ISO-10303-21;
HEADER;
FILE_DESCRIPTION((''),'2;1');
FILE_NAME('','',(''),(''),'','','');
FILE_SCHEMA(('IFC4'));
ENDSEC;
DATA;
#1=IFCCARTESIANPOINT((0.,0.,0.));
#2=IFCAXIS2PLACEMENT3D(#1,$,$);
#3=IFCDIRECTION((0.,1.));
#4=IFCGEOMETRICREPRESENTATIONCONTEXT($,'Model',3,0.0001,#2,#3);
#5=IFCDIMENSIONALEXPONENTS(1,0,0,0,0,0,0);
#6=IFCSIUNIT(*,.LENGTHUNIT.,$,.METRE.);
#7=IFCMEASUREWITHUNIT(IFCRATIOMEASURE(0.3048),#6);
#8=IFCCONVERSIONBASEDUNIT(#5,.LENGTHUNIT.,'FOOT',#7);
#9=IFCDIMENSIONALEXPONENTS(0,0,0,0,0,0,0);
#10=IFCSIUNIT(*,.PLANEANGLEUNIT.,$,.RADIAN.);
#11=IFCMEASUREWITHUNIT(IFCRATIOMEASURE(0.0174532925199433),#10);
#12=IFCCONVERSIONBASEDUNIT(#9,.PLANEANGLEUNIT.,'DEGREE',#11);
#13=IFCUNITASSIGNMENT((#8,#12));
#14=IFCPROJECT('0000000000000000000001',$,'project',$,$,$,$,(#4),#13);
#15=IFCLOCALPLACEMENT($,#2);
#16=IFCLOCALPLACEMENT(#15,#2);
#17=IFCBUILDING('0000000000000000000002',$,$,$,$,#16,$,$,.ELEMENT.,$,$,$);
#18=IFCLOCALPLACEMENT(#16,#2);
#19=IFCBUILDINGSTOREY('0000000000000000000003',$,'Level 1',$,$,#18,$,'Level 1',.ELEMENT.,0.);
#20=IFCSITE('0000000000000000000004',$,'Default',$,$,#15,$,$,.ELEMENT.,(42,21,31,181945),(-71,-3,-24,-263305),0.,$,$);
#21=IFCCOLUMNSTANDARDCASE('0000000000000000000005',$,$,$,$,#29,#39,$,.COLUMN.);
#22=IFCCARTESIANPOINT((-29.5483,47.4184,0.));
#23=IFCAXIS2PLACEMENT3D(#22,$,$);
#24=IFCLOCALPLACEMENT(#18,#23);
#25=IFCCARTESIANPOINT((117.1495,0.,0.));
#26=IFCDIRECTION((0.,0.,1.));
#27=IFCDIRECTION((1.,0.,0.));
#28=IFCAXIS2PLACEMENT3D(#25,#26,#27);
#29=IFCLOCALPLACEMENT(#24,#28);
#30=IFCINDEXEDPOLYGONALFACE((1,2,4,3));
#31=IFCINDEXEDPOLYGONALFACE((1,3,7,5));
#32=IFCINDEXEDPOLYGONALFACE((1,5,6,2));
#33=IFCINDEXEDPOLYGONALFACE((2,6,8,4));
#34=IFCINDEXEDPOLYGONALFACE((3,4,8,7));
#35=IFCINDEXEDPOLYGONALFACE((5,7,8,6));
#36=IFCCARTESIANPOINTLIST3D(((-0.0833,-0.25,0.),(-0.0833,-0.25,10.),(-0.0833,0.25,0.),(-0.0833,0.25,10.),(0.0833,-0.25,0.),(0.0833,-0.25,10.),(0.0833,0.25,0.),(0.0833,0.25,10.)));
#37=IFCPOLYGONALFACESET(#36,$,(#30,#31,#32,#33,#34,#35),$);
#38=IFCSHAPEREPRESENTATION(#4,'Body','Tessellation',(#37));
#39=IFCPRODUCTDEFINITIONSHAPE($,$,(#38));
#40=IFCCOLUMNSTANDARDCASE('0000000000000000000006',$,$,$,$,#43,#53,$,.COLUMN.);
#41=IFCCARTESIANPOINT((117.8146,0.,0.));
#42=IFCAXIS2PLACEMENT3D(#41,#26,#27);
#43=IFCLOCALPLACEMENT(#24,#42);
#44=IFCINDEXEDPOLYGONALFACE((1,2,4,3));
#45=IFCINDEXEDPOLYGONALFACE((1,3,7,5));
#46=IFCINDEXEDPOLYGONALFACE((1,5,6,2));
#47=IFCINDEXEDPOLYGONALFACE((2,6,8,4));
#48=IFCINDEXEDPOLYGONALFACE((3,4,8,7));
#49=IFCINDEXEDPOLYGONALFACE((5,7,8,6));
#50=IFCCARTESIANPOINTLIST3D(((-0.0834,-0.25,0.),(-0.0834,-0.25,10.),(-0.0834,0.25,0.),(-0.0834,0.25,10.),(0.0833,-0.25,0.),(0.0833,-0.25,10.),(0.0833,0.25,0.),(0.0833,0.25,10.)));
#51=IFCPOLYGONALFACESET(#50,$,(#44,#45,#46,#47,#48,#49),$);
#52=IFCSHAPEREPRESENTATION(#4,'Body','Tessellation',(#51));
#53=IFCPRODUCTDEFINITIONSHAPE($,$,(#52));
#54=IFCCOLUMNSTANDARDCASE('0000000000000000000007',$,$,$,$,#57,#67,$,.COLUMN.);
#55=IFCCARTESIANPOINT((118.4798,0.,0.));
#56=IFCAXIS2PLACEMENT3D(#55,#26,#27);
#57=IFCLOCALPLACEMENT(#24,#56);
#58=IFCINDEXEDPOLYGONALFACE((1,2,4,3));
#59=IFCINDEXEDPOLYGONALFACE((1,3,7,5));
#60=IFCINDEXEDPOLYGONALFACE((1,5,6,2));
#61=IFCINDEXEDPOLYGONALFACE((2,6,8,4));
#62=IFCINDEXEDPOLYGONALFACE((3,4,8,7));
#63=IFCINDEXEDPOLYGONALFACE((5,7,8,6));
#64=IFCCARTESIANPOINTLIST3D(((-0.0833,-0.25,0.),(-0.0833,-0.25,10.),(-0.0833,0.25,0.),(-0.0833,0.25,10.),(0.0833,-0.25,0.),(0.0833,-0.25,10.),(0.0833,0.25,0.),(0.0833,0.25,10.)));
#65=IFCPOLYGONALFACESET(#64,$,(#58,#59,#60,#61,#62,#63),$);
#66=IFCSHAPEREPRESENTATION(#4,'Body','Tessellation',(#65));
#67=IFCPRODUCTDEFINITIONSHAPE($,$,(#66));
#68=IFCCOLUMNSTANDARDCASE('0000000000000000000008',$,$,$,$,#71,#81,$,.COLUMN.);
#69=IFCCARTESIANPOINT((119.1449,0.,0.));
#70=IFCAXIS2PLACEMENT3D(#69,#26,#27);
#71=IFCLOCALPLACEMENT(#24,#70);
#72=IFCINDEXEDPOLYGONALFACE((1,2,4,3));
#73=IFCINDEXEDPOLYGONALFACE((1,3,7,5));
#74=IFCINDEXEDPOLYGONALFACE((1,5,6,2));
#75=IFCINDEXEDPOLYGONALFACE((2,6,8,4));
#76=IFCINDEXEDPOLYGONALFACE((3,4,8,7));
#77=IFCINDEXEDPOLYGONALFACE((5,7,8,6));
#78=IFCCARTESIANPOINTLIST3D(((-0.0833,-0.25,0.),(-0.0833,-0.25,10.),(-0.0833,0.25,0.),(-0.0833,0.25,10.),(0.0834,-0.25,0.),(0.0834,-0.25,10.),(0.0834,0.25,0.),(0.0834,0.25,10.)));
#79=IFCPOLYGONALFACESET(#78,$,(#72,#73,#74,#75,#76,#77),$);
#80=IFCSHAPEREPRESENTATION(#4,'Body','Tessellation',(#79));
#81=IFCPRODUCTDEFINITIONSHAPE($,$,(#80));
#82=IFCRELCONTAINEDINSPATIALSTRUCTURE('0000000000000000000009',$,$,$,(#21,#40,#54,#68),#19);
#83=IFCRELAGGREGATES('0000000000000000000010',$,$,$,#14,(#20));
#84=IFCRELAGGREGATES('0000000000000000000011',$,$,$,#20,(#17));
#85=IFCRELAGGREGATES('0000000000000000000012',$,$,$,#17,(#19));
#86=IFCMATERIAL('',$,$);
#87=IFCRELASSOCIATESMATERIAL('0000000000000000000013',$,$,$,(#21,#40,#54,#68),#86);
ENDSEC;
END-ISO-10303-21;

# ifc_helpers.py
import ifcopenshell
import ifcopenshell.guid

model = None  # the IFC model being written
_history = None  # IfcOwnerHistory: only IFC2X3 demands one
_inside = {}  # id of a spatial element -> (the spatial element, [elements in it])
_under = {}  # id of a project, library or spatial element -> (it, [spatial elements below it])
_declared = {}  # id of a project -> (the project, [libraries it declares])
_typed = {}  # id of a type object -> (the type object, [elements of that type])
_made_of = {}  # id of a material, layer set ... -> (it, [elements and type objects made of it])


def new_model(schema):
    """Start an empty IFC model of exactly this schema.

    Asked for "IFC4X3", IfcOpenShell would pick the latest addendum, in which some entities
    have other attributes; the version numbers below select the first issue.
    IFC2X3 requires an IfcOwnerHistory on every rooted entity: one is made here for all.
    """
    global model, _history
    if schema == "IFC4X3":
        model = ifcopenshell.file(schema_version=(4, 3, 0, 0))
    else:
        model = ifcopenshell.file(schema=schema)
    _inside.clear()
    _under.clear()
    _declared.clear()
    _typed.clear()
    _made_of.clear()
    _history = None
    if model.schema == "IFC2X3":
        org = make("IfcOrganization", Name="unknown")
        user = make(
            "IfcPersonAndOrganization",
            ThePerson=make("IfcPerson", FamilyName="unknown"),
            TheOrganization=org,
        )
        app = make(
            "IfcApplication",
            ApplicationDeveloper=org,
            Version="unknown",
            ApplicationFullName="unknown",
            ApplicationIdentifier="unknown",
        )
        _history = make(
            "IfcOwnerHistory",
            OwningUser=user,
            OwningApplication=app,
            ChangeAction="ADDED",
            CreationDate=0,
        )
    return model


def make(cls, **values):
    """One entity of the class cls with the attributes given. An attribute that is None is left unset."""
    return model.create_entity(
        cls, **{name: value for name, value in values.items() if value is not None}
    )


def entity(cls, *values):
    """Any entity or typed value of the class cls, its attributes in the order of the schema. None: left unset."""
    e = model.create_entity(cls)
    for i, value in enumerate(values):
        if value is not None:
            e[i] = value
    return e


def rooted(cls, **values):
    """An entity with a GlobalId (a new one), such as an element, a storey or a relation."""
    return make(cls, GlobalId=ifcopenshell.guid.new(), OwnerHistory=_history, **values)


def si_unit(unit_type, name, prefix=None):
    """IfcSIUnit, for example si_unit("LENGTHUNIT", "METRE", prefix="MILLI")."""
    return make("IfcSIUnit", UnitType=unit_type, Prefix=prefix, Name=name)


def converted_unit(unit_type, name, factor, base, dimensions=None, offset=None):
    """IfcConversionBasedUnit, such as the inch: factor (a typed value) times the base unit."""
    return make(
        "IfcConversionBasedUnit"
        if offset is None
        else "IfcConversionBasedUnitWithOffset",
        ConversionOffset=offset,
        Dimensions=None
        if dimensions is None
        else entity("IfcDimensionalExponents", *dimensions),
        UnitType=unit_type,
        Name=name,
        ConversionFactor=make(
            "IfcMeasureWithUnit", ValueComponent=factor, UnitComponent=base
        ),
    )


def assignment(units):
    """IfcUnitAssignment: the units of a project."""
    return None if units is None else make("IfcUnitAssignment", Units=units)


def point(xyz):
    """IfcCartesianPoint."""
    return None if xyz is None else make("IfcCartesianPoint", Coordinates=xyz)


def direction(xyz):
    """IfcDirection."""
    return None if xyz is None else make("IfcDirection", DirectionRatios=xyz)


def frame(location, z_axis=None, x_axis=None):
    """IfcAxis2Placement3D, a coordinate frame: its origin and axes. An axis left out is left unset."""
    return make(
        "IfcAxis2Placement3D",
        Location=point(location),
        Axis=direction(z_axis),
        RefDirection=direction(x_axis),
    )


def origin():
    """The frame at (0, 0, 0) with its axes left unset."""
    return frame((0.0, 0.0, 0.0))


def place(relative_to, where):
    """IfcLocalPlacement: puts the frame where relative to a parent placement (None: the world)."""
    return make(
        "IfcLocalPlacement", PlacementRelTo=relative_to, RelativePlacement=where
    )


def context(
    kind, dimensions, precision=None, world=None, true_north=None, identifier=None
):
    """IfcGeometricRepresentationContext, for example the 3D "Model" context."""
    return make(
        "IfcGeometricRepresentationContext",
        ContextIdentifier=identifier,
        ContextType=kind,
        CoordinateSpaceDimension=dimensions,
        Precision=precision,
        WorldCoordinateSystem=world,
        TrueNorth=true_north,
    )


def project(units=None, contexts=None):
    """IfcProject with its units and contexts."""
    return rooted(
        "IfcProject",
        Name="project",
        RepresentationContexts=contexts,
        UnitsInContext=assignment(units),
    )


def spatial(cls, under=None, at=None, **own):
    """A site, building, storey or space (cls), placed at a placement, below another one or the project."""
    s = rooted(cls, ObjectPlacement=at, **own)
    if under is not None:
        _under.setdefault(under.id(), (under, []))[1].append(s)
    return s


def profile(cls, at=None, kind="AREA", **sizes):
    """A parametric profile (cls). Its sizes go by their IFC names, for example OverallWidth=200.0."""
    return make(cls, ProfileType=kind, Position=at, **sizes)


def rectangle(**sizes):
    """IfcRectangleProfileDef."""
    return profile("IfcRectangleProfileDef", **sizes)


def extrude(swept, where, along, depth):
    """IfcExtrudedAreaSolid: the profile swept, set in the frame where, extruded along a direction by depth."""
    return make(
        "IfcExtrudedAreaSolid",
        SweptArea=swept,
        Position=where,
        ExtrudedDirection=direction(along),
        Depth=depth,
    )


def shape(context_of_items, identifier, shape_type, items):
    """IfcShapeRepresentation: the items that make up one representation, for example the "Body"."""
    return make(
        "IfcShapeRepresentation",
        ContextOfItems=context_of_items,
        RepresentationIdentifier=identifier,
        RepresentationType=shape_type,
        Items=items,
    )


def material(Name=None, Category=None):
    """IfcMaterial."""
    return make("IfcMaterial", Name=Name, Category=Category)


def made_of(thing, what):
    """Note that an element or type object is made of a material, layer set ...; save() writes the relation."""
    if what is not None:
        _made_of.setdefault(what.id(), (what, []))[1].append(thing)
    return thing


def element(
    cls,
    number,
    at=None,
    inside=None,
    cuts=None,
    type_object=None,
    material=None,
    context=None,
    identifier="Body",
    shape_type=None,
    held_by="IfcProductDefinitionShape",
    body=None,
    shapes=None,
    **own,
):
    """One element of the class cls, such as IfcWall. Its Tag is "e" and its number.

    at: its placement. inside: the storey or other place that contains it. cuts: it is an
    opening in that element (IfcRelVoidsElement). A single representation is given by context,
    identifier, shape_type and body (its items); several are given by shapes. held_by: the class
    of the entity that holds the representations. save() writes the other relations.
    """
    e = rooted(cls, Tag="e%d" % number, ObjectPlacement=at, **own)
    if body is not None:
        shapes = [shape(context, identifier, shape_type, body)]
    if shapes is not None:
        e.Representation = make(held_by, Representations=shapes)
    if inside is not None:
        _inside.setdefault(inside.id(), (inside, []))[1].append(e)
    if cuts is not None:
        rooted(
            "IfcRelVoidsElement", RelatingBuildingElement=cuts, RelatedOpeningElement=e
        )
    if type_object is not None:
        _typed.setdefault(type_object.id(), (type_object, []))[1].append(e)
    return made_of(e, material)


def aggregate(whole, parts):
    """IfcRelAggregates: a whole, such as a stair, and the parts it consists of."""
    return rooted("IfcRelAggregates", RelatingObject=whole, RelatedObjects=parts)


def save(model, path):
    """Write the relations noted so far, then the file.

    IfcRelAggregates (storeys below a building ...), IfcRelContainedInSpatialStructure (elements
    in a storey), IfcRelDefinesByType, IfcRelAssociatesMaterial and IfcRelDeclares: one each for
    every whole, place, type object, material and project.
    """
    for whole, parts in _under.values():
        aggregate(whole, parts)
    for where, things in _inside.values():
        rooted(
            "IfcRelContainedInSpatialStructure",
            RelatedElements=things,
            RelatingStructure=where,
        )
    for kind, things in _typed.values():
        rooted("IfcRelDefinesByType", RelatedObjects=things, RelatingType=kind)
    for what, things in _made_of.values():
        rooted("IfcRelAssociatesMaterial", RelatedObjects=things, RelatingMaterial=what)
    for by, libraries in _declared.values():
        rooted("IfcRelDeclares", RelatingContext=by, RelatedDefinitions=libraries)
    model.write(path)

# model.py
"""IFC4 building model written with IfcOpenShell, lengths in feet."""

from ifc_helpers import new_model, entity, si_unit, converted_unit, direction, frame, origin, place, context, project, spatial, rectangle, extrude, material, element, save


model = new_model("IFC4")

# Units and contexts
model_context = context("Model", 3, precision=0.0001, world=origin(), true_north=direction((0.0, 1.0)))
ifc_project = project(units=[converted_unit("LENGTHUNIT", "FOOT", entity("IfcRatioMeasure", 0.3048), si_unit("LENGTHUNIT", "METRE"), dimensions=[1, 0, 0, 0, 0, 0, 0]), converted_unit("PLANEANGLEUNIT", "DEGREE", entity("IfcRatioMeasure", 0.0174532925199433), si_unit("PLANEANGLEUNIT", "RADIAN"), dimensions=[0, 0, 0, 0, 0, 0, 0])], contexts=[model_context])

# Site, building, storey
site_placement = place(None, origin())
site = spatial("IfcSite", under=ifc_project, at=site_placement, Name="Default", CompositionType="ELEMENT", RefLatitude=(42, 21, 31, 181945), RefLongitude=(-71, -3, -24, -263305), RefElevation=0.0)
building_placement = place(site_placement, origin())
building = spatial("IfcBuilding", under=site, at=building_placement, CompositionType="ELEMENT")
storey_placement = place(building_placement, origin())
storey = spatial("IfcBuildingStorey", under=building, at=storey_placement, Name="Level 1", LongName="Level 1", CompositionType="ELEMENT", Elevation=0.0)

# Columns
ifc_material = material(Name="")
placement = place(storey_placement, frame((-29.5483, 47.4184, 0.0)))
for number, where, z_axis, x_axis in (
    (1, (117.1495, 0.0, 0.0), (0.0, 0.0, 1.0), (1.0, 0.0, 0.0)),
    (2, (117.8146, 0.0, 0.0), (0.0, 0.0, 1.0), (1.0, 0.0, 0.0)),
    (3, (118.4798, 0.0, 0.0), (0.0, 0.0, 1.0), (1.0, 0.0, 0.0)),
    (4, (119.1449, 0.0, 0.0), (0.0, 0.0, 1.0), (1.0, 0.0, 0.0)),
):
    element("IfcColumnStandardCase", number, at=place(placement, frame(where, z_axis=z_axis, x_axis=x_axis)), inside=storey, material=ifc_material, PredefinedType="COLUMN", context=model_context, shape_type="SweptSolid", body=[
        extrude(rectangle(XDim=0.1667, YDim=0.5), origin(), (0.0, 0.0, 1.0), 10.0),
    ])

save(model, "model.ifc")
